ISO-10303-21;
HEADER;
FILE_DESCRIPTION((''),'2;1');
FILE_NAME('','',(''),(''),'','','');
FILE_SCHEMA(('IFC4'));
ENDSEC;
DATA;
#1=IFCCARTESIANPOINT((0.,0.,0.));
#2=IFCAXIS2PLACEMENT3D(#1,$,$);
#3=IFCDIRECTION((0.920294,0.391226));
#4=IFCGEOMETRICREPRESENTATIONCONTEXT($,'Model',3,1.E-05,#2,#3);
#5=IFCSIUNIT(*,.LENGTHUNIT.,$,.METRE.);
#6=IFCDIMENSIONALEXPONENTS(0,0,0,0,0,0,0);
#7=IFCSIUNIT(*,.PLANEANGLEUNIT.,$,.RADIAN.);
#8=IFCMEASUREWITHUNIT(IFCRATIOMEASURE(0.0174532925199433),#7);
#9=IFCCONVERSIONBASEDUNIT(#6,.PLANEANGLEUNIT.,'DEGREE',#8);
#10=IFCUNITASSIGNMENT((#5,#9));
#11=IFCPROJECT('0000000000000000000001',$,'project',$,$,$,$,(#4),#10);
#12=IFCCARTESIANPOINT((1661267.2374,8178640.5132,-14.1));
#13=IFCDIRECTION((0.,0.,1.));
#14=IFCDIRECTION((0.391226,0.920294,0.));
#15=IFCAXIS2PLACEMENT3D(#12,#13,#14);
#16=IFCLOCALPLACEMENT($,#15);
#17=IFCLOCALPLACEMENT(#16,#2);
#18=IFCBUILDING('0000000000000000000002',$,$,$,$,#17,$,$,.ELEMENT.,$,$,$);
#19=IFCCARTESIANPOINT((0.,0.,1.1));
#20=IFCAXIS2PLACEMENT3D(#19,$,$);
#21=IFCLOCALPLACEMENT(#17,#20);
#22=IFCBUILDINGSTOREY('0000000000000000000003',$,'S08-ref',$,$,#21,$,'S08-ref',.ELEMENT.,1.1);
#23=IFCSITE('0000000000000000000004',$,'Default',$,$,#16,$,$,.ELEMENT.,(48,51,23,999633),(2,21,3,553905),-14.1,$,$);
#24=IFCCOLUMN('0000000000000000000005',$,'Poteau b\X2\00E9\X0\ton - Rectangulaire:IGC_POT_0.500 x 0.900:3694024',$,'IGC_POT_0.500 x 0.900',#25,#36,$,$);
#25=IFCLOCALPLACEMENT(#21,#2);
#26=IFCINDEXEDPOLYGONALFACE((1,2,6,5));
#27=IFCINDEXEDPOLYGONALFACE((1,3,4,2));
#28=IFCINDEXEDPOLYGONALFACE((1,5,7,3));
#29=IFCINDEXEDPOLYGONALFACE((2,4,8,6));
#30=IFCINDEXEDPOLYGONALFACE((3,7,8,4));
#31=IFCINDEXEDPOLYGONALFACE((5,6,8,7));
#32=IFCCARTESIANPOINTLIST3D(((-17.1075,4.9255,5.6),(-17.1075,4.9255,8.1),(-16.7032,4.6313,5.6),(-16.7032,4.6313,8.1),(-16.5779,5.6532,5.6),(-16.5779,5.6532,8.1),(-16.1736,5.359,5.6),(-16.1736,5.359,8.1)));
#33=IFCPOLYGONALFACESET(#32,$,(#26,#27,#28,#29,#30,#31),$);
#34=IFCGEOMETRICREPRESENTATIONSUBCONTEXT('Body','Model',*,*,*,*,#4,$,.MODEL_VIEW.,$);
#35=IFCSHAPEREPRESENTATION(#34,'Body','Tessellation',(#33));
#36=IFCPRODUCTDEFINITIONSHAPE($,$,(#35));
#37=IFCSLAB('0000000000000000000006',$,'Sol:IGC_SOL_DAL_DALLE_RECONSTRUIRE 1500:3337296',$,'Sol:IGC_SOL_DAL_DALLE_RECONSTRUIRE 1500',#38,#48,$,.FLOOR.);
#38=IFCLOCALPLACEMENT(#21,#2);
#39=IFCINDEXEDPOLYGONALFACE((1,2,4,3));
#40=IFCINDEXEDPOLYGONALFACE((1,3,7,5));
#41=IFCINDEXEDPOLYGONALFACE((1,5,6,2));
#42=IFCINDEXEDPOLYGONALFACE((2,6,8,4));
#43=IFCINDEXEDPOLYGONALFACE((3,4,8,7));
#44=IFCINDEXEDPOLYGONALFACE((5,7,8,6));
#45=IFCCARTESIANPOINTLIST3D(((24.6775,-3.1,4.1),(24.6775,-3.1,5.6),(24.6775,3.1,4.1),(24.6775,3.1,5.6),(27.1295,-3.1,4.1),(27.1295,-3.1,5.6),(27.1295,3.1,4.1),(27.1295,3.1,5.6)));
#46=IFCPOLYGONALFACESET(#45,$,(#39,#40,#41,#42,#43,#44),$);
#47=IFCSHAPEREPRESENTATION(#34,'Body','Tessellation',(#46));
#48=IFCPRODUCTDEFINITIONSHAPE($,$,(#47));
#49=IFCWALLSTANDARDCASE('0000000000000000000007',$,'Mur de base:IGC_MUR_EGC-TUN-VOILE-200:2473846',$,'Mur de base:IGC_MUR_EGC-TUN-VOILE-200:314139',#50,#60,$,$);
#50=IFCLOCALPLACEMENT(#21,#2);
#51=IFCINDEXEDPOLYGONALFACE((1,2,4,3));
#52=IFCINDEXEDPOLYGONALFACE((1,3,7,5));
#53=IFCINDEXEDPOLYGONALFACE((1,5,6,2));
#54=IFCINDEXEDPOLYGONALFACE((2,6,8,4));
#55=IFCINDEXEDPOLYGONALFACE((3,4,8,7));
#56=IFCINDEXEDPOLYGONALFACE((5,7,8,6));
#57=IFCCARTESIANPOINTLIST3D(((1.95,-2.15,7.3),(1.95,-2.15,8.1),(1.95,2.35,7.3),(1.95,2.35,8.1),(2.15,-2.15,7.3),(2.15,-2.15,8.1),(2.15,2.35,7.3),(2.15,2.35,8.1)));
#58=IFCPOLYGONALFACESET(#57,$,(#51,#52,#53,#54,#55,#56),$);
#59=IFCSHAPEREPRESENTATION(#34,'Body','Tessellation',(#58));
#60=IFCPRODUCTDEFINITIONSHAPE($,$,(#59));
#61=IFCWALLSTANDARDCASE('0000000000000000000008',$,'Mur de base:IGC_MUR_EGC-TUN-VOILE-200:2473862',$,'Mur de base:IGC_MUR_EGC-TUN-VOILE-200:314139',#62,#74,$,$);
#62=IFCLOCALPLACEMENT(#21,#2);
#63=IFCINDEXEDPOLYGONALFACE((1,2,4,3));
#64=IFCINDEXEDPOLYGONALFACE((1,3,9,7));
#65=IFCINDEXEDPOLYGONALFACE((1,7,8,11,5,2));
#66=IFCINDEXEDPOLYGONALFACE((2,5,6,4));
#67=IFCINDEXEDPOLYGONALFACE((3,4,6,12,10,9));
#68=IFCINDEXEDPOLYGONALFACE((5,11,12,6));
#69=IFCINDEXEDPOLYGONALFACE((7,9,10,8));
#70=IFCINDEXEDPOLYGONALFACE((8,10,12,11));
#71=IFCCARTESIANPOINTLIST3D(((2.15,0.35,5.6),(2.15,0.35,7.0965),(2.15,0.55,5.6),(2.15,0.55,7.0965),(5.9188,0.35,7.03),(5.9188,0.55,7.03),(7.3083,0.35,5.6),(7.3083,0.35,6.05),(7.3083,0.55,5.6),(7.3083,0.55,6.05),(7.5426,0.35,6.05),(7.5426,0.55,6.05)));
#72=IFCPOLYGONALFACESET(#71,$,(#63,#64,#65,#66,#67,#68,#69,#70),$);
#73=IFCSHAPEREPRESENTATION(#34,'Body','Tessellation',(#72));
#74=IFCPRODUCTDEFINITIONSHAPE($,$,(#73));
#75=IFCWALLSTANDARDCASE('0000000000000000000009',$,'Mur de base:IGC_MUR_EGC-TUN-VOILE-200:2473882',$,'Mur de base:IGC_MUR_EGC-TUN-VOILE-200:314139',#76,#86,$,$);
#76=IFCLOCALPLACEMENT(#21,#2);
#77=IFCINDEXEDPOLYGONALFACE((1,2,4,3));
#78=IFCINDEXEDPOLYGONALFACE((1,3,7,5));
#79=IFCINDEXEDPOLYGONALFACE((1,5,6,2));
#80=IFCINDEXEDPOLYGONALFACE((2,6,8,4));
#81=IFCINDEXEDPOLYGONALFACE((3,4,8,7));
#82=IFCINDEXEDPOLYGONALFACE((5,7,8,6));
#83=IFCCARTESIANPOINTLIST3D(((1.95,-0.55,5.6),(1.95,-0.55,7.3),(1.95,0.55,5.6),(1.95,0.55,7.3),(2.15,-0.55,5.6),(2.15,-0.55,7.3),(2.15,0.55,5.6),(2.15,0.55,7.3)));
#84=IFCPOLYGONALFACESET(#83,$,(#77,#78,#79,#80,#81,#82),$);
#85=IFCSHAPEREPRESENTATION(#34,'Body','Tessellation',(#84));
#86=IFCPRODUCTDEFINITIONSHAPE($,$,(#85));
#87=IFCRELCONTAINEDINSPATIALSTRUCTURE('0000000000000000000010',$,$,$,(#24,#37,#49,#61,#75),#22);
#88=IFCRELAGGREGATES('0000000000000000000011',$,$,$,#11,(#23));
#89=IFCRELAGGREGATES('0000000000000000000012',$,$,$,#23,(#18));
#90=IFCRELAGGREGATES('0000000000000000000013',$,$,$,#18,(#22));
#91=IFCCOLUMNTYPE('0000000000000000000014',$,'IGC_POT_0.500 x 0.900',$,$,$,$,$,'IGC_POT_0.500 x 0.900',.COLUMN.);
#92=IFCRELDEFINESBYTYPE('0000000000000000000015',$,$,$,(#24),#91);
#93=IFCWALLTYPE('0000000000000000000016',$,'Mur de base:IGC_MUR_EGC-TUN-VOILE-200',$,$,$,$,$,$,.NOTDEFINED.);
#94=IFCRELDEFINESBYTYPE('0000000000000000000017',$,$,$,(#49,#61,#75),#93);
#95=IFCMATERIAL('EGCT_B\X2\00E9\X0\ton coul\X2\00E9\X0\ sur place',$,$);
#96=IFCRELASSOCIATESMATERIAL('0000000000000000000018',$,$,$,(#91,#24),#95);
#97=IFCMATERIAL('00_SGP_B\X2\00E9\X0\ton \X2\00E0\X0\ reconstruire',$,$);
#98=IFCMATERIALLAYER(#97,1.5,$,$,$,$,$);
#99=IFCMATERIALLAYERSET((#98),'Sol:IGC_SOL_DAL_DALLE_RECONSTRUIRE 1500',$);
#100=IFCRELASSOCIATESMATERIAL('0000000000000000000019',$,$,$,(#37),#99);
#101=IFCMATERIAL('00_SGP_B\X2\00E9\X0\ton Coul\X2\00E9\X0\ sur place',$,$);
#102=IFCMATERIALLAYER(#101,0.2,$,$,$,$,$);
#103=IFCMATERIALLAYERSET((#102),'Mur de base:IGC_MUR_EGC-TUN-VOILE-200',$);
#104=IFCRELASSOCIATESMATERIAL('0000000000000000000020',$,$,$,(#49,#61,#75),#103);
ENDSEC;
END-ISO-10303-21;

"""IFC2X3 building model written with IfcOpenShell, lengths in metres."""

from ifc_helpers import new_model, entity, si_unit, converted_unit, direction, frame, frame_2d, origin, place, context, subcontext, project, spatial, polyline, rectangle, extrude, clip, halfspace, bounded_halfspace, source, transform, mapped, material, layer, layer_set, layer_usage, type_object, type_shapes, element, save


model = new_model("IFC2X3")

# Units and contexts
model_context = context("Model", 3, precision=1e-05, world=origin(), true_north=direction((0.920294, 0.391226)))
body_context = subcontext(model_context, "Body", "Model", "MODEL_VIEW")
ifc_project = project(units=[si_unit("LENGTHUNIT", "METRE"), converted_unit("PLANEANGLEUNIT", "DEGREE", entity("IfcRatioMeasure", 0.0174532925199433), si_unit("PLANEANGLEUNIT", "RADIAN"), dimensions=[0, 0, 0, 0, 0, 0, 0])], contexts=[model_context])

# Site, building, storey
site_placement = place(None, frame((1661267.2374, 8178640.5132, -14.1), z_axis=(0.0, 0.0, 1.0), x_axis=(0.391226, 0.920294, 0.0)))
site = spatial("IfcSite", under=ifc_project, at=site_placement, Name="Default", CompositionType="ELEMENT", RefLatitude=(48, 51, 23, 999633), RefLongitude=(2, 21, 3, 553905), RefElevation=-14.1)
building_placement = place(site_placement, origin())
building = spatial("IfcBuilding", under=site, at=building_placement, CompositionType="ELEMENT")
storey_placement = place(building_placement, frame((0.0, 0.0, 1.1)))
storey = spatial("IfcBuildingStorey", under=building, at=storey_placement, Name="S08-ref", LongName="S08-ref", CompositionType="ELEMENT", Elevation=1.1)

# Column
ifc_material_1 = material(Name="EGCT_Béton coulé sur place")
column_type_1 = type_object("IfcColumnType", Name="IGC_POT_0.500 x 0.900", ElementType="IGC_POT_0.500 x 0.900", PredefinedType="COLUMN", material=ifc_material_1)
shared_shape_1 = source(origin(), body_context, "Body", "SweptSolid", [
    extrude(rectangle(XDim=0.5, YDim=0.9, at=frame_2d((0.0, 0.0), x_axis=(1.0, 0.0))), frame((-16.6405, 5.1423, 6.7), z_axis=(0.0, 0.0, 1.0), x_axis=(-0.808536, 0.588447, 0.0)), (0.0, 0.0, 1.0), 2.5),
])
type_shapes(column_type_1, [shared_shape_1])
column_1_placement = place(storey_placement, frame((0.0, 0.0, -1.1)))
element("IfcColumn", 1, at=column_1_placement, inside=storey, type_object=column_type_1, material=ifc_material_1, Name="Poteau béton - Rectangulaire:IGC_POT_0.500 x 0.900:3694024", ObjectType="IGC_POT_0.500 x 0.900", context=body_context, shape_type="MappedRepresentation", body=[
    mapped(shared_shape_1, transform((0.0, 0.0, 0.0), scale=1.0)),
])

# Slab
ifc_material_2 = material(Name="00_SGP_Béton à reconstruire")
ifc_layer_1 = layer(ifc_material_2, 1.5)
ifc_layer_set_1 = layer_set([ifc_layer_1], Name="Sol:IGC_SOL_DAL_DALLE_RECONSTRUIRE 1500")
ifc_layer_usage_1 = layer_usage(ifc_layer_set_1, "AXIS3", "POSITIVE", 0.0)
slab_1_placement = place(storey_placement, origin())
element("IfcSlab", 2, at=slab_1_placement, inside=storey, material=ifc_layer_usage_1, Name="Sol:IGC_SOL_DAL_DALLE_RECONSTRUIRE 1500:3337296", ObjectType="Sol:IGC_SOL_DAL_DALLE_RECONSTRUIRE 1500", PredefinedType="FLOOR", context=body_context, shape_type="SweptSolid", body=[
    extrude(rectangle(XDim=6.2, YDim=2.452, at=frame_2d((0.0, 0.0), x_axis=(1.0, 0.0))), frame((25.9035, 0.0, 5.6), z_axis=(0.0, 0.0, -1.0), x_axis=(0.0, 1.0, 0.0)), (0.0, 0.0, 1.0), 1.5),
])

# Shared definitions
ifc_material_3 = material(Name="00_SGP_Béton Coulé sur place")
ifc_layer_2 = layer(ifc_material_3, 0.2)
ifc_layer_set_2 = layer_set([ifc_layer_2], Name="Mur de base:IGC_MUR_EGC-TUN-VOILE-200")
wall_type = type_object("IfcWallType", Name="Mur de base:IGC_MUR_EGC-TUN-VOILE-200", PredefinedType="NOTDEFINED")

# Walls
ifc_layer_usage_2 = layer_usage(ifc_layer_set_2, "AXIS2", "NEGATIVE", 0.1)
wall_1_placement = place(storey_placement, frame((2.05, -2.15, 7.3), z_axis=(0.0, 0.0, 1.0), x_axis=(0.0, 1.0, 0.0)))
element("IfcWallStandardCase", 3, at=wall_1_placement, inside=storey, type_object=wall_type, material=ifc_layer_usage_2, Name="Mur de base:IGC_MUR_EGC-TUN-VOILE-200:2473846", ObjectType="Mur de base:IGC_MUR_EGC-TUN-VOILE-200:314139", context=body_context, shape_type="SweptSolid", body=[
    extrude(rectangle(XDim=4.5, YDim=0.2, at=frame_2d((2.25, 0.0), x_axis=(-1.0, 0.0))), origin(), (0.0, 0.0, 1.0), 0.8),
])
ifc_layer_usage_3 = layer_usage(ifc_layer_set_2, "AXIS2", "NEGATIVE", 0.1)
wall_2_placement = place(storey_placement, frame((2.15, 0.45, 5.6)))
element("IfcWallStandardCase", 4, at=wall_2_placement, inside=storey, type_object=wall_type, material=ifc_layer_usage_3, Name="Mur de base:IGC_MUR_EGC-TUN-VOILE-200:2473862", ObjectType="Mur de base:IGC_MUR_EGC-TUN-VOILE-200:314139", context=body_context, shape_type="Clipping", body=[
    clip(clip(clip(clip(extrude(rectangle(XDim=5.3926, YDim=0.2, at=frame_2d((2.6963, 0.0), x_axis=(-1.0, 0.0))), origin(), (0.0, 0.0, 1.0), 1.4965), bounded_halfspace(frame((5.1583, 0.1, 0.45), z_axis=(-1.0, 0.0, 0.0), x_axis=(0.0, 1.0, 0.0)), True, frame((5.1583, 0.1, 0.45), z_axis=(-1.0, 0.0, 0.0), x_axis=(0.0, 1.0, 0.0)), polyline([(0.0, 0.0), (0.0, 0.45), (-0.2, 0.45), (-0.2, 0.0), (0.0, 0.0)]))), bounded_halfspace(frame((5.1583, -0.1, 0.45), z_axis=(0.0, 0.0, 1.0), x_axis=(0.0, 1.0, 0.0)), True, frame((5.1583, -0.1, 0.45), z_axis=(0.0, 0.0, 1.0), x_axis=(0.0, 1.0, 0.0)), polyline([(0.0, 0.0), (0.0, -0.2343), (0.2, -0.2343), (0.2, 0.0), (0.0, 0.0)]))), halfspace(frame((0.0, -0.1, 1.4965), z_axis=(0.017635, 0.0, 0.999844), x_axis=(0.0, 1.0, 0.0)), False)), halfspace(frame((3.7688, 0.1, 1.43), z_axis=(0.516703, 0.0, 0.856165), x_axis=(0.0, 1.0, 0.0)), False)),
])
ifc_layer_usage_4 = layer_usage(ifc_layer_set_2, "AXIS2", "NEGATIVE", 0.1)
wall_3_placement = place(storey_placement, frame((2.05, -0.55, 5.6), z_axis=(0.0, 0.0, 1.0), x_axis=(0.0, 1.0, 0.0)))
element("IfcWallStandardCase", 5, at=wall_3_placement, inside=storey, type_object=wall_type, material=ifc_layer_usage_4, Name="Mur de base:IGC_MUR_EGC-TUN-VOILE-200:2473882", ObjectType="Mur de base:IGC_MUR_EGC-TUN-VOILE-200:314139", context=body_context, shape_type="Clipping", body=[
    clip(extrude(rectangle(XDim=1.1, YDim=0.2, at=frame_2d((0.55, 0.0), x_axis=(-1.0, 0.0))), origin(), (0.0, 0.0, 1.0), 1.7), bounded_halfspace(frame((1.1, -0.1, 0.0), z_axis=(0.0, 0.0, 1.0), x_axis=(-1.0, 0.0, 0.0)), True, frame((1.1, -0.1, 0.0)), polyline([(0.0, 0.0), (0.0, 0.2), (-1.1, 0.2), (-1.1, 0.0), (0.0, 0.0)]))),
])

save(model, "model.ifc")
